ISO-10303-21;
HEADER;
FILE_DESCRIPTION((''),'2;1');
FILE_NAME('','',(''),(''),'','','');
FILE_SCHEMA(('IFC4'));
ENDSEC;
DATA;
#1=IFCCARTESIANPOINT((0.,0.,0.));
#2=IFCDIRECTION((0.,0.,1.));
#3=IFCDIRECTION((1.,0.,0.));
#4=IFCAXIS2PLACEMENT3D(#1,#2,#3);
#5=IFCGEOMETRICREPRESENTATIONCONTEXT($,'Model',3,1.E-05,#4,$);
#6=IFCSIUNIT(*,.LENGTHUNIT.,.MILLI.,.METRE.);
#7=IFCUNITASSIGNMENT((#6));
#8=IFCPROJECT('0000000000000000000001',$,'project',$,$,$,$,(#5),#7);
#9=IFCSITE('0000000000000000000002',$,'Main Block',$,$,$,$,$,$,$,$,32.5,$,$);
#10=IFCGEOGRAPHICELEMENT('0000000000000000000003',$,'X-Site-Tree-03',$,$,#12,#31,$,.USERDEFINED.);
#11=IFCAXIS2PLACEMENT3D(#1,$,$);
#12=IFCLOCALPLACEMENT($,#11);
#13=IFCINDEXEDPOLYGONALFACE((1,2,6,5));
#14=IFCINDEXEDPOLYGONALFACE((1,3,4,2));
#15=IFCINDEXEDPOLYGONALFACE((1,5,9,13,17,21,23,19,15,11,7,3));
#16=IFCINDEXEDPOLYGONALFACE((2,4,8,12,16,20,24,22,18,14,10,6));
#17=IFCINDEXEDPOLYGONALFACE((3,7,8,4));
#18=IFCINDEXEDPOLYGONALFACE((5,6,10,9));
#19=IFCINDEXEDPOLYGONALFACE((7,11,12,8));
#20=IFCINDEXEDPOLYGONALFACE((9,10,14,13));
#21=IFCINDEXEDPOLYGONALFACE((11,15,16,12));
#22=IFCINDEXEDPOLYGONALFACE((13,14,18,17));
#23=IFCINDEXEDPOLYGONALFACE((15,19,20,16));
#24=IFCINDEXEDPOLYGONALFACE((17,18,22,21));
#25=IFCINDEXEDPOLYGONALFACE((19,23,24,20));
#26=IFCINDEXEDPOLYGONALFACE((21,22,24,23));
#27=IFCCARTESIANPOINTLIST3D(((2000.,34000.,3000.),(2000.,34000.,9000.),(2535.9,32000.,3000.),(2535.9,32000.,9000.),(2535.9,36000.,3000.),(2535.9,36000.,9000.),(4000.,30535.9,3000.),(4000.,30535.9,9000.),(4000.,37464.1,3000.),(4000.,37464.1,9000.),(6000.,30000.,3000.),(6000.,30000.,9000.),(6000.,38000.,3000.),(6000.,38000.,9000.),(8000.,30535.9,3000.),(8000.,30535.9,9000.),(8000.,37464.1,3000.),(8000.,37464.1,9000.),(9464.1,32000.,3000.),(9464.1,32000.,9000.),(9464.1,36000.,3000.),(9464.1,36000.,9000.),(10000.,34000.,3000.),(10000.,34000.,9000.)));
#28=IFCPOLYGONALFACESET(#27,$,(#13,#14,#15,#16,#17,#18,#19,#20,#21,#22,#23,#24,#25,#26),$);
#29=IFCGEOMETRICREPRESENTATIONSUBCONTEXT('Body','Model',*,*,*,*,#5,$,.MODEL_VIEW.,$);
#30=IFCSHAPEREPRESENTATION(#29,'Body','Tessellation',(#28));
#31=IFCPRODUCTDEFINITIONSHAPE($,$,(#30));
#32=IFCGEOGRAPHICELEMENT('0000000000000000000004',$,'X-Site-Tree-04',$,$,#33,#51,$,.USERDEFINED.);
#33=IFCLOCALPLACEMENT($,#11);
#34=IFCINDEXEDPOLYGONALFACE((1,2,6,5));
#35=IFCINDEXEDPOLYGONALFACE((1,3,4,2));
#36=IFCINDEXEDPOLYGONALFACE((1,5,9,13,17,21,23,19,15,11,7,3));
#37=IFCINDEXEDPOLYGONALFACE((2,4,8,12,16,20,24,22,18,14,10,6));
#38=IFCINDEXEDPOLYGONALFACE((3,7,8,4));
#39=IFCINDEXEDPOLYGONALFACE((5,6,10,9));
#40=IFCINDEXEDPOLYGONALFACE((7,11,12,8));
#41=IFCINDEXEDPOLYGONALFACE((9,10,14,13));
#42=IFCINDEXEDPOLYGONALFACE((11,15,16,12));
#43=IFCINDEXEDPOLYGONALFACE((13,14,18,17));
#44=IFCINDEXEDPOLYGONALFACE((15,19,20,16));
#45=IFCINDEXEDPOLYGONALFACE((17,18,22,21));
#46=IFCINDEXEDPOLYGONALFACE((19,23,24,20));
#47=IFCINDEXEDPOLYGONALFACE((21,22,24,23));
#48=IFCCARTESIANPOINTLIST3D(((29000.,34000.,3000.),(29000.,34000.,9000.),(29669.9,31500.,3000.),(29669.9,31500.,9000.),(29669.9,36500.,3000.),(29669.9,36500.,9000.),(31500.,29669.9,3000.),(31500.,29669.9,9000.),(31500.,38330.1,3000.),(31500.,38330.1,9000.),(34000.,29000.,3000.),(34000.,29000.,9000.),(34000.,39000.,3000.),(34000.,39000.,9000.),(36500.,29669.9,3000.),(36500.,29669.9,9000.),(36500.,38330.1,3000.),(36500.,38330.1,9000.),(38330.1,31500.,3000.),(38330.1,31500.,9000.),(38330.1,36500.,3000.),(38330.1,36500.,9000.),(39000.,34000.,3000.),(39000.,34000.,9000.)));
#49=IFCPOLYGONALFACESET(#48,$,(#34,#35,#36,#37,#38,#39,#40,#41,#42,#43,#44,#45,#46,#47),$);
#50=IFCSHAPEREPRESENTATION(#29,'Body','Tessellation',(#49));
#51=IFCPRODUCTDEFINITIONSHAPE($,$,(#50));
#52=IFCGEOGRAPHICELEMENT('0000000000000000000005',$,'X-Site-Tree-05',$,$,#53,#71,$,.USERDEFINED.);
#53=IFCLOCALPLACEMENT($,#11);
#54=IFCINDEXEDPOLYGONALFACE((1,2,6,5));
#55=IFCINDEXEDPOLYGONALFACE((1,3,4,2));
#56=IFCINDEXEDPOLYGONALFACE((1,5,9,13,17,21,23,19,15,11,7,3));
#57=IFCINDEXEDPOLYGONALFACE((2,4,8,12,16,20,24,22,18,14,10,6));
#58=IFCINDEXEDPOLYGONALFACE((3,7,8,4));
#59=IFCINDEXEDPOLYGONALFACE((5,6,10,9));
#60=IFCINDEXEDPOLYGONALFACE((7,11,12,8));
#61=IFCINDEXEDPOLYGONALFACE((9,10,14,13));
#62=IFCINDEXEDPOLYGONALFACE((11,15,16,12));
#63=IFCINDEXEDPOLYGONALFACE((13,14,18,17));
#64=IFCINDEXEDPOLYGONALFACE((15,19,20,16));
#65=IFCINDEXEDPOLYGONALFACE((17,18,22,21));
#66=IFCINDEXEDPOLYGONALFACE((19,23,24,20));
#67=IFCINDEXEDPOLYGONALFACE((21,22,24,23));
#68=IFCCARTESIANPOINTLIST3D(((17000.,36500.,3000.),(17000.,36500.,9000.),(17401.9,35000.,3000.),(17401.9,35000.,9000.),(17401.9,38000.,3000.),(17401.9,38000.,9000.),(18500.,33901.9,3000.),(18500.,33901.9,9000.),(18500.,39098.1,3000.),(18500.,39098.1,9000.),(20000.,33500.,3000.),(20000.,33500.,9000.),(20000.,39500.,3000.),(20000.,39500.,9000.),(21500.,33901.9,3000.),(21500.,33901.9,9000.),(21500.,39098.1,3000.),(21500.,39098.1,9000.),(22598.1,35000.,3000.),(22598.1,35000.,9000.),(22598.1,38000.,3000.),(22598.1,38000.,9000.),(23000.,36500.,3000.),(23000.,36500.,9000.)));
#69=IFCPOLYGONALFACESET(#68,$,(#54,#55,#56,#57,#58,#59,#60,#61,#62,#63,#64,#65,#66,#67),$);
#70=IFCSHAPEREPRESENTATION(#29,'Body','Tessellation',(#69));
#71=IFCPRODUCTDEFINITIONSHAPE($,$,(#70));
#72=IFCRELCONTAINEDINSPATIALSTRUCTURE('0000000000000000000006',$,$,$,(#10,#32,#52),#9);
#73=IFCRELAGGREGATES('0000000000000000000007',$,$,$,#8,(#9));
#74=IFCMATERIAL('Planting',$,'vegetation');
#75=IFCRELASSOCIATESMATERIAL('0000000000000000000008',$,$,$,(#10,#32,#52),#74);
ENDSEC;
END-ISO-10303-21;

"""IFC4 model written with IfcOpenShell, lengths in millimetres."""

from ifc_helpers import new_model, si_unit, frame, origin_with_axes, place, context, subcontext, project, spatial, indexed_curve, outline, extrude, material, element, save


model = new_model("IFC4")

# Units and contexts
model_context = context("Model", 3, precision=1e-05, world=origin_with_axes())
body_context = subcontext(model_context, "Body", "Model", "MODEL_VIEW")
ifc_project = project(units=[si_unit("LENGTHUNIT", "METRE", prefix="MILLI")], contexts=[model_context])

# Site
site = spatial("IfcSite", under=ifc_project, Name="Main Block", RefElevation=32.5)

# Geographic elements
ifc_material_1 = material(Name="Planting", Category="vegetation")
geographic_element_1_placement = place(None, frame((0.0, 0.0, 3000.0), z_axis=(0.0, 0.0, 1.0), x_axis=(1.0, 0.0, 0.0)))
element("IfcGeographicElement", 1, at=geographic_element_1_placement, inside=site, material=ifc_material_1, Name="X-Site-Tree-03", PredefinedType="USERDEFINED", context=body_context, shape_type="SweptSolid", body=[
    extrude(outline(indexed_curve([(10000.0, 34000.0), (9464.1, 36000.0), (8000.0, 37464.1), (6000.0, 38000.0), (4000.0, 37464.1), (2535.9, 36000.0), (2000.0, 34000.0), (2535.9, 32000.0), (4000.0, 30535.9), (6000.0, 30000.0), (8000.0, 30535.9), (9464.1, 32000.0)])), None, (0.0, 0.0, 1.0), 6000.0),
])
geographic_element_2_placement = place(None, frame((0.0, 0.0, 3000.0), z_axis=(0.0, 0.0, 1.0), x_axis=(1.0, 0.0, 0.0)))
element("IfcGeographicElement", 2, at=geographic_element_2_placement, inside=site, material=ifc_material_1, Name="X-Site-Tree-04", PredefinedType="USERDEFINED", context=body_context, shape_type="SweptSolid", body=[
    extrude(outline(indexed_curve([(39000.0, 34000.0), (38330.1, 36500.0), (36500.0, 38330.1), (34000.0, 39000.0), (31500.0, 38330.1), (29669.9, 36500.0), (29000.0, 34000.0), (29669.9, 31500.0), (31500.0, 29669.9), (34000.0, 29000.0), (36500.0, 29669.9), (38330.1, 31500.0)])), None, (0.0, 0.0, 1.0), 6000.0),
])
geographic_element_3_placement = place(None, frame((0.0, 0.0, 3000.0), z_axis=(0.0, 0.0, 1.0), x_axis=(1.0, 0.0, 0.0)))
element("IfcGeographicElement", 3, at=geographic_element_3_placement, inside=site, material=ifc_material_1, Name="X-Site-Tree-05", PredefinedType="USERDEFINED", context=body_context, shape_type="SweptSolid", body=[
    extrude(outline(indexed_curve([(23000.0, 36500.0), (22598.1, 38000.0), (21500.0, 39098.1), (20000.0, 39500.0), (18500.0, 39098.1), (17401.9, 38000.0), (17000.0, 36500.0), (17401.9, 35000.0), (18500.0, 33901.9), (20000.0, 33500.0), (21500.0, 33901.9), (22598.1, 35000.0)])), None, (0.0, 0.0, 1.0), 6000.0),
])

save(model, "model.ifc")
